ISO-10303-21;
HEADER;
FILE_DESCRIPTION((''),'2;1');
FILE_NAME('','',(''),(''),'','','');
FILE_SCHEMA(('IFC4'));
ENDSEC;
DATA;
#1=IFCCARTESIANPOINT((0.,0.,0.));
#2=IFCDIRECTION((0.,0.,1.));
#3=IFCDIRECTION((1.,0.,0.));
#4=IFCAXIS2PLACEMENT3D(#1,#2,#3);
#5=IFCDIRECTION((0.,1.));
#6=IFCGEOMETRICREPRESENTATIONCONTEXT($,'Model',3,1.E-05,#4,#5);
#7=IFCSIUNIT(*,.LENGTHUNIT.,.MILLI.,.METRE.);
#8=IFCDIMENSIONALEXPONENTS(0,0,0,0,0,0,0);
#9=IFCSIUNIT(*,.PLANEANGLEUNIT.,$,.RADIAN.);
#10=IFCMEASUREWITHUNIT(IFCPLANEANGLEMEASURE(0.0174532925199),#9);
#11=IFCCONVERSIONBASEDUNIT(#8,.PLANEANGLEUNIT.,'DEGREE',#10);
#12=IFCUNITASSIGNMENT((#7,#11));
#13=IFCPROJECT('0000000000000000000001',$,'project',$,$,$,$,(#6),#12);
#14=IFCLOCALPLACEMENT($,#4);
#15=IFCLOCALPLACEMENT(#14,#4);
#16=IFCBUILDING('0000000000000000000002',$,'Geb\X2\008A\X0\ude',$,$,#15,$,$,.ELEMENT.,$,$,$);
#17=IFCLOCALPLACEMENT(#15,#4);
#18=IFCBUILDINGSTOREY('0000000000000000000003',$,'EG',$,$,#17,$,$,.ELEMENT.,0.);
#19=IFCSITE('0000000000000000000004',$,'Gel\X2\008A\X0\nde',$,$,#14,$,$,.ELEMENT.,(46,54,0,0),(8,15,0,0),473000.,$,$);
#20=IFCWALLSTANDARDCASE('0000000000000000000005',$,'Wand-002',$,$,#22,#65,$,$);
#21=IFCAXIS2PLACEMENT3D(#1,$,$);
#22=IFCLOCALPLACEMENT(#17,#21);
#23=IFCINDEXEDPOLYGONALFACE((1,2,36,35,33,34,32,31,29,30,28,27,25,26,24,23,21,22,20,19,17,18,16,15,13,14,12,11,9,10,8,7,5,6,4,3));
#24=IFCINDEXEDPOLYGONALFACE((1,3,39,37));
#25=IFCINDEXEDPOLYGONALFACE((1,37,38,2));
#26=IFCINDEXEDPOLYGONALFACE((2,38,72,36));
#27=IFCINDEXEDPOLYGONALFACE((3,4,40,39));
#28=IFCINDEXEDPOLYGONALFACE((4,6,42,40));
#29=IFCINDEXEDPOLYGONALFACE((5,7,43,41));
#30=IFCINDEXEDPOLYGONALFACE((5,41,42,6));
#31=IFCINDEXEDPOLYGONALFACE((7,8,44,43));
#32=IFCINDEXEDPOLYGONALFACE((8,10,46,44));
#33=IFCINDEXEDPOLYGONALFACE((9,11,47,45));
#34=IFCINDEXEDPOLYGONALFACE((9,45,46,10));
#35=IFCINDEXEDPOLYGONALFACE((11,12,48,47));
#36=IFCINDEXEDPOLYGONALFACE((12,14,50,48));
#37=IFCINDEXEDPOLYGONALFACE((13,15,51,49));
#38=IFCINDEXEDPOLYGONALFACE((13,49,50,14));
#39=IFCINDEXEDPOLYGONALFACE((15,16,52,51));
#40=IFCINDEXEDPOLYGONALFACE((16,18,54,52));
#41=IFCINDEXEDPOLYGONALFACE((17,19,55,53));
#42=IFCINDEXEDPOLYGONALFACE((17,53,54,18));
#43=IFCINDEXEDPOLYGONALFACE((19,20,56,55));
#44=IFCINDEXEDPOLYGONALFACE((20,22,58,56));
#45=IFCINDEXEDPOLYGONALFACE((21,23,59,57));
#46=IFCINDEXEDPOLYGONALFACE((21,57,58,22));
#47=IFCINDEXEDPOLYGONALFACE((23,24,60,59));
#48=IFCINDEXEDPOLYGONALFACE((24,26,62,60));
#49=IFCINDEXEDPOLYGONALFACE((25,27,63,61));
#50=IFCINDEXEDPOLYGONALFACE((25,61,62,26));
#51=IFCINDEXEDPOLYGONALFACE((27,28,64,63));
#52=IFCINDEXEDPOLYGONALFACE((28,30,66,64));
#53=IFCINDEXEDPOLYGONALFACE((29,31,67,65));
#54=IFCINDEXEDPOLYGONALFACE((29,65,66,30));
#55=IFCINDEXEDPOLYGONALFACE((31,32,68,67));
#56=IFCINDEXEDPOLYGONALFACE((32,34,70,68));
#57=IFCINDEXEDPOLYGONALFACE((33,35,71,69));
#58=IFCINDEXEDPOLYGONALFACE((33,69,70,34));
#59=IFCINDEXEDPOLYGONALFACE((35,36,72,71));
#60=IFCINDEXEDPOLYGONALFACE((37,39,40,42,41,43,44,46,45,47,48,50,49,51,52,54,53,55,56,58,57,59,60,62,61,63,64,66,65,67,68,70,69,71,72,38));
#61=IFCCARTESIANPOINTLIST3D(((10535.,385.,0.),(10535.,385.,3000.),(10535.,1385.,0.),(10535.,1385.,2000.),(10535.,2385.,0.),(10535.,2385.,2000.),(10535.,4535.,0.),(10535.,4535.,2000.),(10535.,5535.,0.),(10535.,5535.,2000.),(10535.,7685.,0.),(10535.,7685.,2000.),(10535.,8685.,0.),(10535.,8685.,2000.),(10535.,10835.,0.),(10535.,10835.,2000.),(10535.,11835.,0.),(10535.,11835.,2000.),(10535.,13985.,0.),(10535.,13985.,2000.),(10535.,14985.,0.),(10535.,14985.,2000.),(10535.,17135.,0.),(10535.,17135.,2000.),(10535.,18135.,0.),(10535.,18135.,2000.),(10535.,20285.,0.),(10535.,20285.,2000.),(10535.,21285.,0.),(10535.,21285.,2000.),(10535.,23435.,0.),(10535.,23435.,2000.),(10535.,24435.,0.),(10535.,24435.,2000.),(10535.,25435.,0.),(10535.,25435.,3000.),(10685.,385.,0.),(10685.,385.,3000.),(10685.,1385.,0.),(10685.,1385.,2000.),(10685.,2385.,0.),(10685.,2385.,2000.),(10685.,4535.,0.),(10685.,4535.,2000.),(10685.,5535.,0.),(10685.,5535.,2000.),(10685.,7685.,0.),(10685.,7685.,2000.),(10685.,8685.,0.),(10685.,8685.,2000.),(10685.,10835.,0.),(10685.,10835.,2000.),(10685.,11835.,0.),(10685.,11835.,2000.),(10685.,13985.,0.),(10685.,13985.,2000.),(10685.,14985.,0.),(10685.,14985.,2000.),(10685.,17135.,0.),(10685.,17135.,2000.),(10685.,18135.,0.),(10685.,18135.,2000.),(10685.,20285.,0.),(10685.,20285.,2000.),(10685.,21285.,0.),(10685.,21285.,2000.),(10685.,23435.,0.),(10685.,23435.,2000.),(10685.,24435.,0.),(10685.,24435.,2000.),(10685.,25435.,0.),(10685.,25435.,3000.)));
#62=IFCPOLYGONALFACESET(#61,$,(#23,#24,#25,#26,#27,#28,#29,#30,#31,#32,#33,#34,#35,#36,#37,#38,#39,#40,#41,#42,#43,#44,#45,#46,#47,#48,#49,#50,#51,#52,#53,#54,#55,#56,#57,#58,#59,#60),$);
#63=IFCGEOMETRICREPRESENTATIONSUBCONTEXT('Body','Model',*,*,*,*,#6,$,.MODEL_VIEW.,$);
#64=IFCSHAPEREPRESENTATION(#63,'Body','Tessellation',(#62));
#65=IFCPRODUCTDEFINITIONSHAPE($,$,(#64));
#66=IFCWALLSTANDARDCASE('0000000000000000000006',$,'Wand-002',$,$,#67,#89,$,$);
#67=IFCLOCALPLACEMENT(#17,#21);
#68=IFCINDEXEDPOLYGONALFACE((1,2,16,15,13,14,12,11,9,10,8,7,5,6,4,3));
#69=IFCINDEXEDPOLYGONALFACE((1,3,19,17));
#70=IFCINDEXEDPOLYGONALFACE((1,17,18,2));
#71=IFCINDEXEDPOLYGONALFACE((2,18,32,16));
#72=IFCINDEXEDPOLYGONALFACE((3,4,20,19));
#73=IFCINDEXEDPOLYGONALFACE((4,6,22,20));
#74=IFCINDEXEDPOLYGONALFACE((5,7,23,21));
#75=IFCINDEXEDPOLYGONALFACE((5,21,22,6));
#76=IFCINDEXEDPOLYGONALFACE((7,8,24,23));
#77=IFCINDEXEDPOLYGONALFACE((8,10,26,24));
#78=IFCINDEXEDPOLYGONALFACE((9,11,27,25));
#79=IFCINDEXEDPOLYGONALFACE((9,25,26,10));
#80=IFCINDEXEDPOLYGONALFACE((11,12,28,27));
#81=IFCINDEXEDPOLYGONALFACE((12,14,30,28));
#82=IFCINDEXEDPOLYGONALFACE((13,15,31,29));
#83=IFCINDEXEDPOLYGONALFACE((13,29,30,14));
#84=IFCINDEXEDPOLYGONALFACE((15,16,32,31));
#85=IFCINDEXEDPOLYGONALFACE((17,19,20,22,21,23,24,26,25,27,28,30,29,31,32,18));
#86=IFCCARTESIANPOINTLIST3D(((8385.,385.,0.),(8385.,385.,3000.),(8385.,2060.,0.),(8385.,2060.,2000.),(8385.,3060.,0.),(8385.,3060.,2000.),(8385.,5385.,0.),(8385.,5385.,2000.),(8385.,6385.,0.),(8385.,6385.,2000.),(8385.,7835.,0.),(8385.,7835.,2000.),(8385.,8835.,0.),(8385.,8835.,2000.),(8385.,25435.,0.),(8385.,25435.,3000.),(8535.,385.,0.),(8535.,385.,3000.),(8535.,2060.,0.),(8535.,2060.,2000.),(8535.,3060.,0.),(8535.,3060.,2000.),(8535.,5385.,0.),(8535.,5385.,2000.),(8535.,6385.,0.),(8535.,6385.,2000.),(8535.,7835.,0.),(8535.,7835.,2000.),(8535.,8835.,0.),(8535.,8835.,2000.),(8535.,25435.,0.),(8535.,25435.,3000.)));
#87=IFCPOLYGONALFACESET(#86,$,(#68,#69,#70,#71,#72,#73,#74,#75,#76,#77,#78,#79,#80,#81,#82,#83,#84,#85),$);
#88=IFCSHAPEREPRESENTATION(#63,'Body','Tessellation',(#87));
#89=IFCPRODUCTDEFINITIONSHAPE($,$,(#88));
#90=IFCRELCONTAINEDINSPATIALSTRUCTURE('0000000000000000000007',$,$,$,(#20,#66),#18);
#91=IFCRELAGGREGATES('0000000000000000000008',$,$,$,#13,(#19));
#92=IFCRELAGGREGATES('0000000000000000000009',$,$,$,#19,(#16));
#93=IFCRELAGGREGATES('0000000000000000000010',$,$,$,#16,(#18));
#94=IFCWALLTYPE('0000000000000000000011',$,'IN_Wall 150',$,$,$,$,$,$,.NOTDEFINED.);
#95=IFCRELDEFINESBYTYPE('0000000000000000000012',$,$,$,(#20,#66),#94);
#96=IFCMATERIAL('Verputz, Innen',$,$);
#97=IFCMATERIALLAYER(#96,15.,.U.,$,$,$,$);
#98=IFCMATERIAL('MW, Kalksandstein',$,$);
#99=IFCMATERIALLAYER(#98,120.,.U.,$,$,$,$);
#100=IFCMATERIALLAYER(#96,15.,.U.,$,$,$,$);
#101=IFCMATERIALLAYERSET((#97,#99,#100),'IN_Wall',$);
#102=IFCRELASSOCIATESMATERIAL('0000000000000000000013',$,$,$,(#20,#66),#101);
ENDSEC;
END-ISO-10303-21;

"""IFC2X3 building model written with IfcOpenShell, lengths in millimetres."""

from ifc_helpers import new_model, entity, si_unit, converted_unit, direction, frame, origin_with_axes, origin_2d_with_axis, place, context, subcontext, project, spatial, polyline, rectangle, outline, extrude, material, layer, layer_set, layer_usage, type_object, element, save


model = new_model("IFC2X3")

# Units and contexts
model_context = context("Model", 3, precision=1e-05, world=origin_with_axes(), true_north=direction((0.0, 1.0)))
body_context = subcontext(model_context, "Body", "Model", "MODEL_VIEW")
ifc_project = project(units=[si_unit("LENGTHUNIT", "METRE", prefix="MILLI"), converted_unit("PLANEANGLEUNIT", "DEGREE", entity("IfcPlaneAngleMeasure", 0.0174532925199), si_unit("PLANEANGLEUNIT", "RADIAN"), dimensions=[0, 0, 0, 0, 0, 0, 0])], contexts=[model_context])

# Site, building, storey
site_placement = place(None, origin_with_axes())
site = spatial("IfcSite", under=ifc_project, at=site_placement, Name="Gel\u008ande", CompositionType="ELEMENT", RefLatitude=(46, 54, 0, 0), RefLongitude=(8, 15, 0, 0), RefElevation=473000.0)
building_placement = place(site_placement, origin_with_axes())
building = spatial("IfcBuilding", under=site, at=building_placement, Name="Geb\u008aude", CompositionType="ELEMENT")
storey_placement = place(building_placement, origin_with_axes())
storey = spatial("IfcBuildingStorey", under=building, at=storey_placement, Name="EG", CompositionType="ELEMENT", Elevation=0.0)

# Shared definitions
ifc_material_1 = material(Name="Verputz, Innen")

# Wall, openings
ifc_layer_1 = layer(ifc_material_1, 15.0, ventilated="UNKNOWN")
ifc_material_2 = material(Name="MW, Kalksandstein")
ifc_layer_2 = layer(ifc_material_2, 120.0, ventilated="UNKNOWN")
ifc_layer_3 = layer(ifc_material_1, 15.0, ventilated="UNKNOWN")
ifc_layer_set_1 = layer_set([ifc_layer_1, ifc_layer_2, ifc_layer_3], Name="IN_Wall")
ifc_layer_usage_1 = layer_usage(ifc_layer_set_1, "AXIS2", "POSITIVE", 0.0)
wall_type_1 = type_object("IfcWallType", Name="IN_Wall 150", PredefinedType="NOTDEFINED")
wall_1_placement = place(storey_placement, frame((10535.0, 25820.0, 0.0), z_axis=(0.0, 0.0, 1.0), x_axis=(0.0, -1.0, 0.0)))
wall_1 = element("IfcWallStandardCase", 1, at=wall_1_placement, inside=storey, type_object=wall_type_1, material=ifc_layer_usage_1, Name="Wand-002", context=body_context, shape_type="SweptSolid", body=[
    extrude(outline(polyline([(385.0, 0.0), (25435.0, 0.0), (25435.0, 150.0), (385.0, 150.0), (385.0, 0.0)])), origin_with_axes(), (0.0, 0.0, 1.0), 3000.0),
])
opening_1_placement = place(wall_1_placement, frame((1885.0, 0.0, 0.0), z_axis=(0.0, 0.0, 1.0), x_axis=(1.0, 0.0, 0.0)))
element("IfcOpeningElement", 2, at=opening_1_placement, cuts=wall_1, context=body_context, shape_type="SweptSolid", body=[
    extrude(rectangle(XDim=1000.0, YDim=2000.0, at=origin_2d_with_axis()), frame((0.0, -150.0, 1000.0), z_axis=(0.0, -1.0, 0.0), x_axis=(-1.0, 0.0, 0.0)), (0.0, 0.0, -1.0), 450.0),
])
opening_2_placement = place(wall_1_placement, frame((5035.0, 0.0, 0.0), z_axis=(0.0, 0.0, 1.0), x_axis=(1.0, 0.0, 0.0)))
element("IfcOpeningElement", 3, at=opening_2_placement, cuts=wall_1, context=body_context, shape_type="SweptSolid", body=[
    extrude(rectangle(XDim=1000.0, YDim=2000.0, at=origin_2d_with_axis()), frame((0.0, -150.0, 1000.0), z_axis=(0.0, -1.0, 0.0), x_axis=(-1.0, 0.0, 0.0)), (0.0, 0.0, -1.0), 450.0),
])
opening_3_placement = place(wall_1_placement, frame((8185.0, 0.0, 0.0), z_axis=(0.0, 0.0, 1.0), x_axis=(1.0, 0.0, 0.0)))
element("IfcOpeningElement", 4, at=opening_3_placement, cuts=wall_1, context=body_context, shape_type="SweptSolid", body=[
    extrude(rectangle(XDim=1000.0, YDim=2000.0, at=origin_2d_with_axis()), frame((0.0, -150.0, 1000.0), z_axis=(0.0, -1.0, 0.0), x_axis=(-1.0, 0.0, 0.0)), (0.0, 0.0, -1.0), 450.0),
])
opening_4_placement = place(wall_1_placement, frame((11335.0, 0.0, 0.0), z_axis=(0.0, 0.0, 1.0), x_axis=(1.0, 0.0, 0.0)))
element("IfcOpeningElement", 5, at=opening_4_placement, cuts=wall_1, context=body_context, shape_type="SweptSolid", body=[
    extrude(rectangle(XDim=1000.0, YDim=2000.0, at=origin_2d_with_axis()), frame((0.0, -150.0, 1000.0), z_axis=(0.0, -1.0, 0.0), x_axis=(-1.0, 0.0, 0.0)), (0.0, 0.0, -1.0), 450.0),
])
opening_5_placement = place(wall_1_placement, frame((14485.0, 0.0, 0.0), z_axis=(0.0, 0.0, 1.0), x_axis=(1.0, 0.0, 0.0)))
element("IfcOpeningElement", 6, at=opening_5_placement, cuts=wall_1, context=body_context, shape_type="SweptSolid", body=[
    extrude(rectangle(XDim=1000.0, YDim=2000.0, at=origin_2d_with_axis()), frame((0.0, -150.0, 1000.0), z_axis=(0.0, -1.0, 0.0), x_axis=(-1.0, 0.0, 0.0)), (0.0, 0.0, -1.0), 450.0),
])
opening_6_placement = place(wall_1_placement, frame((17635.0, 0.0, 0.0), z_axis=(0.0, 0.0, 1.0), x_axis=(1.0, 0.0, 0.0)))
element("IfcOpeningElement", 7, at=opening_6_placement, cuts=wall_1, context=body_context, shape_type="SweptSolid", body=[
    extrude(rectangle(XDim=1000.0, YDim=2000.0, at=origin_2d_with_axis()), frame((0.0, -150.0, 1000.0), z_axis=(0.0, -1.0, 0.0), x_axis=(-1.0, 0.0, 0.0)), (0.0, 0.0, -1.0), 450.0),
])
opening_7_placement = place(wall_1_placement, frame((20785.0, 0.0, 0.0), z_axis=(0.0, 0.0, 1.0), x_axis=(1.0, 0.0, 0.0)))
element("IfcOpeningElement", 8, at=opening_7_placement, cuts=wall_1, context=body_context, shape_type="SweptSolid", body=[
    extrude(rectangle(XDim=1000.0, YDim=2000.0, at=origin_2d_with_axis()), frame((0.0, -150.0, 1000.0), z_axis=(0.0, -1.0, 0.0), x_axis=(-1.0, 0.0, 0.0)), (0.0, 0.0, -1.0), 450.0),
])
opening_8_placement = place(wall_1_placement, frame((23935.0, 0.0, 0.0), z_axis=(0.0, 0.0, 1.0), x_axis=(1.0, 0.0, 0.0)))
element("IfcOpeningElement", 9, at=opening_8_placement, cuts=wall_1, context=body_context, shape_type="SweptSolid", body=[
    extrude(rectangle(XDim=1000.0, YDim=2000.0, at=origin_2d_with_axis()), frame((0.0, -150.0, 1000.0), z_axis=(0.0, -1.0, 0.0), x_axis=(-1.0, 0.0, 0.0)), (0.0, 0.0, -1.0), 450.0),
])

# Wall, openings
ifc_layer_usage_2 = layer_usage(ifc_layer_set_1, "AXIS2", "POSITIVE", 0.0)
wall_2_placement = place(storey_placement, frame((8385.0, 25820.0, 0.0), z_axis=(0.0, 0.0, 1.0), x_axis=(0.0, -1.0, 0.0)))
wall_2 = element("IfcWallStandardCase", 10, at=wall_2_placement, inside=storey, type_object=wall_type_1, material=ifc_layer_usage_2, Name="Wand-002", context=body_context, shape_type="SweptSolid", body=[
    extrude(outline(polyline([(385.0, 0.0), (25435.0, 0.0), (25435.0, 150.0), (385.0, 150.0), (385.0, 0.0)])), origin_with_axes(), (0.0, 0.0, 1.0), 3000.0),
])
opening_9_placement = place(wall_2_placement, frame((17485.0, 0.0, 0.0), z_axis=(0.0, 0.0, 1.0), x_axis=(1.0, 0.0, 0.0)))
element("IfcOpeningElement", 11, at=opening_9_placement, cuts=wall_2, context=body_context, shape_type="SweptSolid", body=[
    extrude(rectangle(XDim=1000.0, YDim=2000.0, at=origin_2d_with_axis()), frame((0.0, -150.0, 1000.0), z_axis=(0.0, -1.0, 0.0), x_axis=(1.0, 0.0, 0.0)), (0.0, 0.0, -1.0), 450.0),
])
opening_10_placement = place(wall_2_placement, frame((23260.0, 0.0, 0.0), z_axis=(0.0, 0.0, 1.0), x_axis=(1.0, 0.0, 0.0)))
element("IfcOpeningElement", 12, at=opening_10_placement, cuts=wall_2, context=body_context, shape_type="SweptSolid", body=[
    extrude(rectangle(XDim=1000.0, YDim=2000.0, at=origin_2d_with_axis()), frame((0.0, 150.0, 1000.0), z_axis=(0.0, -1.0, 0.0), x_axis=(-1.0, 0.0, 0.0)), (0.0, 0.0, 1.0), 450.0),
])
opening_11_placement = place(wall_2_placement, frame((19935.0, 0.0, 0.0), z_axis=(0.0, 0.0, 1.0), x_axis=(1.0, 0.0, 0.0)))
element("IfcOpeningElement", 13, at=opening_11_placement, cuts=wall_2, context=body_context, shape_type="SweptSolid", body=[
    extrude(rectangle(XDim=1000.0, YDim=2000.0, at=origin_2d_with_axis()), frame((0.0, 150.0, 1000.0), z_axis=(0.0, -1.0, 0.0), x_axis=(-1.0, 0.0, 0.0)), (0.0, 0.0, 1.0), 450.0),
])

save(model, "model.ifc")
